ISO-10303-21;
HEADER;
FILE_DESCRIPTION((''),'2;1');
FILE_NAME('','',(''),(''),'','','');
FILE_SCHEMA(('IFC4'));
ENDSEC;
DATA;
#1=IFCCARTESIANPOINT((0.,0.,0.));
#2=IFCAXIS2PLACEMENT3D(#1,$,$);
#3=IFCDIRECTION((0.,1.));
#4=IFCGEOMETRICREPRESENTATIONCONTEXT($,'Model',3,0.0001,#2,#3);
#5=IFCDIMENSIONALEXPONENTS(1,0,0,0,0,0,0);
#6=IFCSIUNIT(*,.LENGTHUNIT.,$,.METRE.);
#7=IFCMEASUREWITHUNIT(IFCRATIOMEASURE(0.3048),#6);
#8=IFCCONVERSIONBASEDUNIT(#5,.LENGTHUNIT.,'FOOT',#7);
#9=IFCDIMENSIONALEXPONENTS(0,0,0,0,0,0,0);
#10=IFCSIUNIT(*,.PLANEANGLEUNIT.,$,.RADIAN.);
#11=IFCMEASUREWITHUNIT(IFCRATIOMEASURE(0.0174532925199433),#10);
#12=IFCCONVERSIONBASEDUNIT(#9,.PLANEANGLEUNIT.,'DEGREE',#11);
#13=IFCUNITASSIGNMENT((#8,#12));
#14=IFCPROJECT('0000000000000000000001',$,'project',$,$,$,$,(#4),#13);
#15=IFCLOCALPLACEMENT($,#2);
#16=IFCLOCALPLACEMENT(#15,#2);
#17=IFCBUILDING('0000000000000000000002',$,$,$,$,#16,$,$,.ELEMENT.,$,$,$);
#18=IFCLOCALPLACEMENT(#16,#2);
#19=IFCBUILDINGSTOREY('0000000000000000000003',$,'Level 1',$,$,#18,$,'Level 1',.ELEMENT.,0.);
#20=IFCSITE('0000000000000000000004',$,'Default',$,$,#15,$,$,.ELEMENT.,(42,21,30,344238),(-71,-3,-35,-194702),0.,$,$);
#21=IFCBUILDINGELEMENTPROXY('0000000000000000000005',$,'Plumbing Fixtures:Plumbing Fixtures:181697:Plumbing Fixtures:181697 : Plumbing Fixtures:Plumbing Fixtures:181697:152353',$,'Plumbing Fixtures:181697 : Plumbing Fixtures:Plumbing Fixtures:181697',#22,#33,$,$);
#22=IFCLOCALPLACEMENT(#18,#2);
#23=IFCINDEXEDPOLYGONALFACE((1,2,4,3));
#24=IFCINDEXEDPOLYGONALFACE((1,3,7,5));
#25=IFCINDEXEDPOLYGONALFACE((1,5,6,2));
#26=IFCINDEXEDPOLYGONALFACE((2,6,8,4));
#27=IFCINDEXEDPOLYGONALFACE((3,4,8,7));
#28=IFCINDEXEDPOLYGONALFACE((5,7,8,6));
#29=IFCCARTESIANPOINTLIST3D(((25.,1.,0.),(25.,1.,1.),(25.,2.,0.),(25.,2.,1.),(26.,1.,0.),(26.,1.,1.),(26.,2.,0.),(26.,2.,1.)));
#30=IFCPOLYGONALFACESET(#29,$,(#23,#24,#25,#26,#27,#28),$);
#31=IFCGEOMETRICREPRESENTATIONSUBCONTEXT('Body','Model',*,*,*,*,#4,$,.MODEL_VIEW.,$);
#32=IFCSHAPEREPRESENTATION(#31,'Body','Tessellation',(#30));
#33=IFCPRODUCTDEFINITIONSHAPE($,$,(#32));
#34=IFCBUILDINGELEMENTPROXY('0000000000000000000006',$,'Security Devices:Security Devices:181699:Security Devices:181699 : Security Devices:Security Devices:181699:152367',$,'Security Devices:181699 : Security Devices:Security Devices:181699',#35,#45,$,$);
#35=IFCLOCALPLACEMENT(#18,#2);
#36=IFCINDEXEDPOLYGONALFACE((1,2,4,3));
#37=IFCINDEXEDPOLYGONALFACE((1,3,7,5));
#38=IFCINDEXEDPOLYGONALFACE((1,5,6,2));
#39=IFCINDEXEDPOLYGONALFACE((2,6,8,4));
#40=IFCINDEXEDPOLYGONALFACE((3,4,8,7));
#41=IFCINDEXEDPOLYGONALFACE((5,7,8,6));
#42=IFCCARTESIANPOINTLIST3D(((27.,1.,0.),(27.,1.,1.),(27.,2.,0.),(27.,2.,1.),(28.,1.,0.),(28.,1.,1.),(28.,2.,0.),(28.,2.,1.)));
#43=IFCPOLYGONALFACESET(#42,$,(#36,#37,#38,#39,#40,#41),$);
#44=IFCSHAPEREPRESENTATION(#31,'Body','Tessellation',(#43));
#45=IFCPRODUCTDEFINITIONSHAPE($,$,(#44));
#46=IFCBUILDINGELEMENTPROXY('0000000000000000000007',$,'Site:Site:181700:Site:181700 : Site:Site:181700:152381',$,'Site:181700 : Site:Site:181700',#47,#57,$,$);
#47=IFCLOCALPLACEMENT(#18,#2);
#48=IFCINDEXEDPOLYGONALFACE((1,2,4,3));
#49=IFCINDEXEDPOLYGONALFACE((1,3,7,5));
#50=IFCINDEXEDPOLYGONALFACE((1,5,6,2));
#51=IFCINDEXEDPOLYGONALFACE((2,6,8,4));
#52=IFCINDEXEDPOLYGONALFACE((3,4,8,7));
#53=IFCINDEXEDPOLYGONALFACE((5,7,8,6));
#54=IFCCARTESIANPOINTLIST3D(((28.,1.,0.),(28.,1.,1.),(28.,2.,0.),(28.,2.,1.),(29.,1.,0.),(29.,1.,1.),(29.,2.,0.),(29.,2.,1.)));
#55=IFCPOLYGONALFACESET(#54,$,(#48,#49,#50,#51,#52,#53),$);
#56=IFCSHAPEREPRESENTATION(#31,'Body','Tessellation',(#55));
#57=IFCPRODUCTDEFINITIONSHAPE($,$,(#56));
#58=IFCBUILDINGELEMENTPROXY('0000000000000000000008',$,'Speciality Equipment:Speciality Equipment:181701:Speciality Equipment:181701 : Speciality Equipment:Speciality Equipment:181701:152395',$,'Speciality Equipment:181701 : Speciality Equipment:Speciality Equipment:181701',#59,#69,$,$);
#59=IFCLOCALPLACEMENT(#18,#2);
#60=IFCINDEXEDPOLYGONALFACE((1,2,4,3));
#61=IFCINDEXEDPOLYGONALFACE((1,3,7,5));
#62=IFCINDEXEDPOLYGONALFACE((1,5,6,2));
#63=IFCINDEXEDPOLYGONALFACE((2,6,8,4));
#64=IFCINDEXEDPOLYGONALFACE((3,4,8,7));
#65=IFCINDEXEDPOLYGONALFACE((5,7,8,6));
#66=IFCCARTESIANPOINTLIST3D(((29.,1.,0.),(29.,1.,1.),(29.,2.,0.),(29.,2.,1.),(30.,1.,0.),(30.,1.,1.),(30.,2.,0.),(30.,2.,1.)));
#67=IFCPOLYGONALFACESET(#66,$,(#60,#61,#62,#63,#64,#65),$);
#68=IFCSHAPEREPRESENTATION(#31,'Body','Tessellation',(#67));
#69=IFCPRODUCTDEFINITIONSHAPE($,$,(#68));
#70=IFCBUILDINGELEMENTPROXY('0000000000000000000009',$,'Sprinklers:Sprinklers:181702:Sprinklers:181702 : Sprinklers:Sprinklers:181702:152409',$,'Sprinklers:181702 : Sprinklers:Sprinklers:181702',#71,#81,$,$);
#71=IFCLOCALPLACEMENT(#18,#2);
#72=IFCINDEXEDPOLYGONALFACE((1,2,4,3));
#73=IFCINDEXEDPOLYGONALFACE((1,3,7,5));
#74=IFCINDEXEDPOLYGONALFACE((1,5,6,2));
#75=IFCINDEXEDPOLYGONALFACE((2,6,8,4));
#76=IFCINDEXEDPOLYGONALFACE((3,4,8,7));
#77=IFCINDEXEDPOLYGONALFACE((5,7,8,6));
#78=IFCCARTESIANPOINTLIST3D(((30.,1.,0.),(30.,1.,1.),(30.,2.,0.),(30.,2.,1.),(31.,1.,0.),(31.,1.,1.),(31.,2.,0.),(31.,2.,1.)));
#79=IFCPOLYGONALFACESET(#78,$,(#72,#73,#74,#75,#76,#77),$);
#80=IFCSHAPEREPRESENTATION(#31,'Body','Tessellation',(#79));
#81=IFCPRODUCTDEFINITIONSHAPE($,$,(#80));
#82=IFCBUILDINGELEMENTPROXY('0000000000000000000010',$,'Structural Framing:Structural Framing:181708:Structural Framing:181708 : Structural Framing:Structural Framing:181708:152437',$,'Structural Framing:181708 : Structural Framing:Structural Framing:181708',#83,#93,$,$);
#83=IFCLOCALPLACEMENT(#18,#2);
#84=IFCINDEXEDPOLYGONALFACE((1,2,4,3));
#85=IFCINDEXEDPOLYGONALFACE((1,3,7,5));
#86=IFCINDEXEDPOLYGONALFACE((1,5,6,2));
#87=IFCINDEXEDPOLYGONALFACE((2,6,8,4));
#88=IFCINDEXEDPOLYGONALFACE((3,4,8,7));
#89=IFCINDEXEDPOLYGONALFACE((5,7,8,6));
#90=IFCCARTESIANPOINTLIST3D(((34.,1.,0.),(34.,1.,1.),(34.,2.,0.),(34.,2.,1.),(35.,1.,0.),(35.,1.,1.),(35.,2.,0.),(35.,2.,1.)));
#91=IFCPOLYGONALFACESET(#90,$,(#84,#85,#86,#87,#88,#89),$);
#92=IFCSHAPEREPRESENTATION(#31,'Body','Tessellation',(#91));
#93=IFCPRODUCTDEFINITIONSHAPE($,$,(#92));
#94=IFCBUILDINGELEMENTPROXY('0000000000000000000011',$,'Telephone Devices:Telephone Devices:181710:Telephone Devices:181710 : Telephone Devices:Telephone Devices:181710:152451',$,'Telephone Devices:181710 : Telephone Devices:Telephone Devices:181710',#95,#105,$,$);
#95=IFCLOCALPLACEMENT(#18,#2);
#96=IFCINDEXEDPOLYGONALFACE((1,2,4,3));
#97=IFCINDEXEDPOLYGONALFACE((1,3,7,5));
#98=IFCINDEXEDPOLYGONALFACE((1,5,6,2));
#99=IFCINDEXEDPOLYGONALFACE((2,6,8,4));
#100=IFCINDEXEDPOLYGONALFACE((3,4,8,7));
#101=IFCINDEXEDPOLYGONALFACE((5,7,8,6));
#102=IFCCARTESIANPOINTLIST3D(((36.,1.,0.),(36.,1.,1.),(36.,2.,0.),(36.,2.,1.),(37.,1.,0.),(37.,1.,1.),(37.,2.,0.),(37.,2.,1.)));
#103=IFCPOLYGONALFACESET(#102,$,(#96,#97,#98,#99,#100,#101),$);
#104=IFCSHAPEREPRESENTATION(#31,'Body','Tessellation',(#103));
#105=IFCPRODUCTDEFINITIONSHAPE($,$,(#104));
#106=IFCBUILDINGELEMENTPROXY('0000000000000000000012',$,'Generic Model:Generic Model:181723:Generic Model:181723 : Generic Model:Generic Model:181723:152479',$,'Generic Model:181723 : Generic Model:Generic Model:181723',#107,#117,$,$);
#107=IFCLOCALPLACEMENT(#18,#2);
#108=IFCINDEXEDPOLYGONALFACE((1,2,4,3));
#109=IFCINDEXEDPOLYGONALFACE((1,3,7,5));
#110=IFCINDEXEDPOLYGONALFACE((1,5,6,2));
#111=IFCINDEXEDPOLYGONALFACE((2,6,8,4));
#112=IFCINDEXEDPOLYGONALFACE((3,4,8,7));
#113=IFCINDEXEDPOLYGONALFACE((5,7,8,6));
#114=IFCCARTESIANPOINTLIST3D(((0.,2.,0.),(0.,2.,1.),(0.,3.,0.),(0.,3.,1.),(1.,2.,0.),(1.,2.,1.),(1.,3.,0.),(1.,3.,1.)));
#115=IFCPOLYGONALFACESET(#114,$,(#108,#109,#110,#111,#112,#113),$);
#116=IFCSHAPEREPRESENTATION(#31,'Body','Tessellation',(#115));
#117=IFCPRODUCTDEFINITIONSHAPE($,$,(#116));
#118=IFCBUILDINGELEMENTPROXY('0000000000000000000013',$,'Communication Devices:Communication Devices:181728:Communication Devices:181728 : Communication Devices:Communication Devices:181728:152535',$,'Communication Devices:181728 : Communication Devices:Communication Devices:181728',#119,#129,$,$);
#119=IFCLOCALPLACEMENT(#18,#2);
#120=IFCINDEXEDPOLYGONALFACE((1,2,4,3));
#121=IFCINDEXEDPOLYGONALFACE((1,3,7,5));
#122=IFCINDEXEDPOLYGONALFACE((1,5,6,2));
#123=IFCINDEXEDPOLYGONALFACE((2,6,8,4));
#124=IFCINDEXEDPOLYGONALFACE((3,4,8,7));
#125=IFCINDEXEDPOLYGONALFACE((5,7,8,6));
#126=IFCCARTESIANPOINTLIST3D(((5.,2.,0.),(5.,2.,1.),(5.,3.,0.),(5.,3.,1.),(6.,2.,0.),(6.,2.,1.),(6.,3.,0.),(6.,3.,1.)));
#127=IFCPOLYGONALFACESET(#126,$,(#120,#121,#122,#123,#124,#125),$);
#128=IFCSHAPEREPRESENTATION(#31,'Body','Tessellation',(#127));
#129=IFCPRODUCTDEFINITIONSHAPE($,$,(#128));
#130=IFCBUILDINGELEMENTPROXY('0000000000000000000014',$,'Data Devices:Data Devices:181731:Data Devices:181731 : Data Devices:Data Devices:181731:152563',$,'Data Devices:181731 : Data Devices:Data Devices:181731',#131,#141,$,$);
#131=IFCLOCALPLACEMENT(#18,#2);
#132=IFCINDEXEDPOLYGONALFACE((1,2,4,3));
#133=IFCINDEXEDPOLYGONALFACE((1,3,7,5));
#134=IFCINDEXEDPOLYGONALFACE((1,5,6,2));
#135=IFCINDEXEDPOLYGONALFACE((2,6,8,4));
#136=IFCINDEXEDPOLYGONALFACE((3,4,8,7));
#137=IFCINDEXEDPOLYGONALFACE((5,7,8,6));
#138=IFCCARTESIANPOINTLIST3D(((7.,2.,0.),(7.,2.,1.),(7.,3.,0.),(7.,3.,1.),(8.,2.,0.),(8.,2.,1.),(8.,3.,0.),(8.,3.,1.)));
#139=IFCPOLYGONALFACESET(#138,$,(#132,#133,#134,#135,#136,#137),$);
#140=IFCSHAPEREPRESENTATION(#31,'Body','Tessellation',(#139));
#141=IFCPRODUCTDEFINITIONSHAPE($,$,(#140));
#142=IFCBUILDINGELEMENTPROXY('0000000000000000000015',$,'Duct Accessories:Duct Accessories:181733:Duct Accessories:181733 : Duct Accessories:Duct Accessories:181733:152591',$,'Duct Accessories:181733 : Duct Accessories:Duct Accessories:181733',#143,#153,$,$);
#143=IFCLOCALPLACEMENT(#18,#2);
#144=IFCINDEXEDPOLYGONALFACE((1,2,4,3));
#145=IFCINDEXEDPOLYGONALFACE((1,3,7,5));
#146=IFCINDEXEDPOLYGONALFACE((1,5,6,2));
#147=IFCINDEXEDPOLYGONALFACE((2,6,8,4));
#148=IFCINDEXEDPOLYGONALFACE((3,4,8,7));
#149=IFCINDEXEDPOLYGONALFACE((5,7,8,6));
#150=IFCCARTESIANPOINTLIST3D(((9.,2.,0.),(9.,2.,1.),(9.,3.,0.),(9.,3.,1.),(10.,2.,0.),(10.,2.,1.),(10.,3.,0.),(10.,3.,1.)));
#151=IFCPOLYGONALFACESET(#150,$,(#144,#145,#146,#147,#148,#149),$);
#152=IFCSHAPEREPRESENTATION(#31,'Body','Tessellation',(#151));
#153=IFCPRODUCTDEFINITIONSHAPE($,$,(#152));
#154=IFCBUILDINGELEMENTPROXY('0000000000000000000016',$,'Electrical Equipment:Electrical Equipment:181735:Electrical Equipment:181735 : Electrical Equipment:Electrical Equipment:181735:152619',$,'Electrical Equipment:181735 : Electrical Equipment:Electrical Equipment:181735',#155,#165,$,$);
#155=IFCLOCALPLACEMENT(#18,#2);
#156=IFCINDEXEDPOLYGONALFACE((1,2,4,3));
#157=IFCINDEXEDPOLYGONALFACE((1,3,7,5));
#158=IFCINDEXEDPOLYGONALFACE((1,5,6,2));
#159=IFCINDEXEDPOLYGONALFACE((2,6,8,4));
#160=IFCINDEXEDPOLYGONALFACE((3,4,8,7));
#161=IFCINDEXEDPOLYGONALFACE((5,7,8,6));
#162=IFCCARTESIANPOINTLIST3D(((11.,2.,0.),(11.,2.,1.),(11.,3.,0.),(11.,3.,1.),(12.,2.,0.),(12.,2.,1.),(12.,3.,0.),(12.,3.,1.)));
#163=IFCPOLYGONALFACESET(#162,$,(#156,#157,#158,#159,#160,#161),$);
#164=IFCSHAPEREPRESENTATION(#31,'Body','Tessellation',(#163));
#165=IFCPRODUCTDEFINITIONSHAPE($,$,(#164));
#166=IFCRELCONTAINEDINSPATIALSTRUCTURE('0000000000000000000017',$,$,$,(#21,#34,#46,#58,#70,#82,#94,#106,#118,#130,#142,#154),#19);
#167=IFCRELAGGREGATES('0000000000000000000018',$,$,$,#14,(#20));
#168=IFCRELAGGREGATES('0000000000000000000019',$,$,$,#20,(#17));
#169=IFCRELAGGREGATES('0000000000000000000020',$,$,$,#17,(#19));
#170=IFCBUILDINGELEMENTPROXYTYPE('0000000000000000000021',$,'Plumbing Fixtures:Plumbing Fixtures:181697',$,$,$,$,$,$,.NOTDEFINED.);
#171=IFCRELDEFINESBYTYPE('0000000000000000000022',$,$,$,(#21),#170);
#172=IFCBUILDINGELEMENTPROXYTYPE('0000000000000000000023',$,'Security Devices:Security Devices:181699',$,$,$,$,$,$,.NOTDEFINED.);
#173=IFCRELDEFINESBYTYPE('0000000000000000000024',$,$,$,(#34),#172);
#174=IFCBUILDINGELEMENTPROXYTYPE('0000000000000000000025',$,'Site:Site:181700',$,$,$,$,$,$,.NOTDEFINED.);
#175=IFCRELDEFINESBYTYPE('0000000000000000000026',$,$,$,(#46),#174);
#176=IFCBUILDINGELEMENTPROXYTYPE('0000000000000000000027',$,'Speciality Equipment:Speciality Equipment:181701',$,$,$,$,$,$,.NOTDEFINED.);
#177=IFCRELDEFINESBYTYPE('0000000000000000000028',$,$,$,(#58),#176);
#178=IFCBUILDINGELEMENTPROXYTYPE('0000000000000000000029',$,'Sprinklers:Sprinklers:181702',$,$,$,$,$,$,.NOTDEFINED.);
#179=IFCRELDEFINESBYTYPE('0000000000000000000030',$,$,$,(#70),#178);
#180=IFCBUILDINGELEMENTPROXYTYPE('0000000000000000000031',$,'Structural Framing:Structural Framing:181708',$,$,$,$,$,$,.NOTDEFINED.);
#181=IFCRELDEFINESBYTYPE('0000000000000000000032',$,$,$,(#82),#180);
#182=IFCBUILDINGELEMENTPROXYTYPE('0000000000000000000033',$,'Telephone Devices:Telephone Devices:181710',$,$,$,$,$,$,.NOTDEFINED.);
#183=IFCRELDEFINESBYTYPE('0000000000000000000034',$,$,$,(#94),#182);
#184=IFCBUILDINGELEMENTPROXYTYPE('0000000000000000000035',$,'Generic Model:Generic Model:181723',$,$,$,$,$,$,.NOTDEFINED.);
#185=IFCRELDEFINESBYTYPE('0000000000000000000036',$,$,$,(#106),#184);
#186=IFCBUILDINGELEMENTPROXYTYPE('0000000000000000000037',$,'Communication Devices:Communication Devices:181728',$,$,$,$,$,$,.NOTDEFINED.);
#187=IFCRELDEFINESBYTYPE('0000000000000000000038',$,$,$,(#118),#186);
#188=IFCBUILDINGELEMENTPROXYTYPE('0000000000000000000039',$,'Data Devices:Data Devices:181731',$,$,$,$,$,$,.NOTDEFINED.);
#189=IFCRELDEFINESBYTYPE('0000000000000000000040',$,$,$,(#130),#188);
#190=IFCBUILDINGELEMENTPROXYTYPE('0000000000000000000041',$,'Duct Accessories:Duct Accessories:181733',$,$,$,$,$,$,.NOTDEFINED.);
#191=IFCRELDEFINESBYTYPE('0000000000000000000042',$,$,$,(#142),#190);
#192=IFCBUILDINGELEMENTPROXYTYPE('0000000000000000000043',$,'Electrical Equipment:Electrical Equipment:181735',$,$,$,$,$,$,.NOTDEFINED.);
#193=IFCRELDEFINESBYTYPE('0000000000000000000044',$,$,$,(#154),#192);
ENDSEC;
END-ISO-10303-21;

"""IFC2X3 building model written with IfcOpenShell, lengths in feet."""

from ifc_helpers import new_model, entity, si_unit, converted_unit, direction, frame, frame_2d, origin, place, context, subcontext, project, spatial, rectangle, extrude, source, transform, mapped, type_object, type_shapes, element, save


model = new_model("IFC2X3")

# Units and contexts
model_context = context("Model", 3, precision=0.0001, world=origin(), true_north=direction((0.0, 1.0)))
body_context = subcontext(model_context, "Body", "Model", "MODEL_VIEW")
ifc_project = project(units=[converted_unit("LENGTHUNIT", "FOOT", entity("IfcRatioMeasure", 0.3048), si_unit("LENGTHUNIT", "METRE"), dimensions=[1, 0, 0, 0, 0, 0, 0]), converted_unit("PLANEANGLEUNIT", "DEGREE", entity("IfcRatioMeasure", 0.0174532925199433), si_unit("PLANEANGLEUNIT", "RADIAN"), dimensions=[0, 0, 0, 0, 0, 0, 0])], contexts=[model_context])

# Site, building, storey
site_placement = place(None, origin())
site = spatial("IfcSite", under=ifc_project, at=site_placement, Name="Default", CompositionType="ELEMENT", RefLatitude=(42, 21, 30, 344238), RefLongitude=(-71, -3, -35, -194702), RefElevation=0.0)
building_placement = place(site_placement, origin())
building = spatial("IfcBuilding", under=site, at=building_placement, CompositionType="ELEMENT")
storey_placement = place(building_placement, origin())
storey = spatial("IfcBuildingStorey", under=building, at=storey_placement, Name="Level 1", LongName="Level 1", CompositionType="ELEMENT", Elevation=0.0)

# Building element proxies
building_element_proxy_type_1 = type_object("IfcBuildingElementProxyType", Name="Plumbing Fixtures:Plumbing Fixtures:181697", PredefinedType="NOTDEFINED")
shared_shape_1 = source(origin(), body_context, "Body", "SweptSolid", [
    extrude(rectangle(XDim=1.0, YDim=1.0, at=frame_2d((0.0, 0.0), x_axis=(1.0, 0.0))), frame((25.5, 1.5, 0.0), z_axis=(0.0, 0.0, 1.0), x_axis=(-1.0, 0.0, 0.0)), (0.0, 0.0, 1.0), 1.0),
])
type_shapes(building_element_proxy_type_1, [shared_shape_1])
proxy_1_placement = place(storey_placement, origin())
element("IfcBuildingElementProxy", 1, at=proxy_1_placement, inside=storey, type_object=building_element_proxy_type_1, Name="Plumbing Fixtures:Plumbing Fixtures:181697:Plumbing Fixtures:181697 : Plumbing Fixtures:Plumbing Fixtures:181697:152353", ObjectType="Plumbing Fixtures:181697 : Plumbing Fixtures:Plumbing Fixtures:181697", context=body_context, shape_type="MappedRepresentation", body=[
    mapped(shared_shape_1, transform((0.0, 0.0, 0.0), scale=1.0)),
])
building_element_proxy_type_2 = type_object("IfcBuildingElementProxyType", Name="Security Devices:Security Devices:181699", PredefinedType="NOTDEFINED")
shared_shape_2 = source(origin(), body_context, "Body", "SweptSolid", [
    extrude(rectangle(XDim=1.0, YDim=1.0, at=frame_2d((0.0, 0.0), x_axis=(1.0, 0.0))), frame((27.5, 1.5, 0.0), z_axis=(0.0, 0.0, 1.0), x_axis=(-1.0, 0.0, 0.0)), (0.0, 0.0, 1.0), 1.0),
])
type_shapes(building_element_proxy_type_2, [shared_shape_2])
proxy_2_placement = place(storey_placement, origin())
element("IfcBuildingElementProxy", 2, at=proxy_2_placement, inside=storey, type_object=building_element_proxy_type_2, Name="Security Devices:Security Devices:181699:Security Devices:181699 : Security Devices:Security Devices:181699:152367", ObjectType="Security Devices:181699 : Security Devices:Security Devices:181699", context=body_context, shape_type="MappedRepresentation", body=[
    mapped(shared_shape_2, transform((0.0, 0.0, 0.0), scale=1.0)),
])
building_element_proxy_type_3 = type_object("IfcBuildingElementProxyType", Name="Site:Site:181700", PredefinedType="NOTDEFINED")
shared_shape_3 = source(origin(), body_context, "Body", "SweptSolid", [
    extrude(rectangle(XDim=1.0, YDim=1.0, at=frame_2d((0.0, 0.0), x_axis=(1.0, 0.0))), frame((28.5, 1.5, 0.0), z_axis=(0.0, 0.0, 1.0), x_axis=(-1.0, 0.0, 0.0)), (0.0, 0.0, 1.0), 1.0),
])
type_shapes(building_element_proxy_type_3, [shared_shape_3])
proxy_3_placement = place(storey_placement, origin())
element("IfcBuildingElementProxy", 3, at=proxy_3_placement, inside=storey, type_object=building_element_proxy_type_3, Name="Site:Site:181700:Site:181700 : Site:Site:181700:152381", ObjectType="Site:181700 : Site:Site:181700", context=body_context, shape_type="MappedRepresentation", body=[
    mapped(shared_shape_3, transform((0.0, 0.0, 0.0), scale=1.0)),
])
building_element_proxy_type_4 = type_object("IfcBuildingElementProxyType", Name="Speciality Equipment:Speciality Equipment:181701", PredefinedType="NOTDEFINED")
shared_shape_4 = source(origin(), body_context, "Body", "SweptSolid", [
    extrude(rectangle(XDim=1.0, YDim=1.0, at=frame_2d((0.0, 0.0), x_axis=(1.0, 0.0))), frame((29.5, 1.5, 0.0), z_axis=(0.0, 0.0, 1.0), x_axis=(-1.0, 0.0, 0.0)), (0.0, 0.0, 1.0), 1.0),
])
type_shapes(building_element_proxy_type_4, [shared_shape_4])
proxy_4_placement = place(storey_placement, origin())
element("IfcBuildingElementProxy", 4, at=proxy_4_placement, inside=storey, type_object=building_element_proxy_type_4, Name="Speciality Equipment:Speciality Equipment:181701:Speciality Equipment:181701 : Speciality Equipment:Speciality Equipment:181701:152395", ObjectType="Speciality Equipment:181701 : Speciality Equipment:Speciality Equipment:181701", context=body_context, shape_type="MappedRepresentation", body=[
    mapped(shared_shape_4, transform((0.0, 0.0, 0.0), scale=1.0)),
])
building_element_proxy_type_5 = type_object("IfcBuildingElementProxyType", Name="Sprinklers:Sprinklers:181702", PredefinedType="NOTDEFINED")
shared_shape_5 = source(origin(), body_context, "Body", "SweptSolid", [
    extrude(rectangle(XDim=1.0, YDim=1.0, at=frame_2d((0.0, 0.0), x_axis=(1.0, 0.0))), frame((30.5, 1.5, 0.0), z_axis=(0.0, 0.0, 1.0), x_axis=(-1.0, 0.0, 0.0)), (0.0, 0.0, 1.0), 1.0),
])
type_shapes(building_element_proxy_type_5, [shared_shape_5])
proxy_5_placement = place(storey_placement, origin())
element("IfcBuildingElementProxy", 5, at=proxy_5_placement, inside=storey, type_object=building_element_proxy_type_5, Name="Sprinklers:Sprinklers:181702:Sprinklers:181702 : Sprinklers:Sprinklers:181702:152409", ObjectType="Sprinklers:181702 : Sprinklers:Sprinklers:181702", context=body_context, shape_type="MappedRepresentation", body=[
    mapped(shared_shape_5, transform((0.0, 0.0, 0.0), scale=1.0)),
])
building_element_proxy_type_6 = type_object("IfcBuildingElementProxyType", Name="Structural Framing:Structural Framing:181708", PredefinedType="NOTDEFINED")
shared_shape_6 = source(origin(), body_context, "Body", "SweptSolid", [
    extrude(rectangle(XDim=1.0, YDim=1.0, at=frame_2d((0.0, 0.0), x_axis=(1.0, 0.0))), frame((34.5, 1.5, 0.0), z_axis=(0.0, 0.0, 1.0), x_axis=(-1.0, 0.0, 0.0)), (0.0, 0.0, 1.0), 1.0),
])
type_shapes(building_element_proxy_type_6, [shared_shape_6])
proxy_6_placement = place(storey_placement, origin())
element("IfcBuildingElementProxy", 6, at=proxy_6_placement, inside=storey, type_object=building_element_proxy_type_6, Name="Structural Framing:Structural Framing:181708:Structural Framing:181708 : Structural Framing:Structural Framing:181708:152437", ObjectType="Structural Framing:181708 : Structural Framing:Structural Framing:181708", context=body_context, shape_type="MappedRepresentation", body=[
    mapped(shared_shape_6, transform((0.0, 0.0, 0.0), scale=1.0)),
])
building_element_proxy_type_7 = type_object("IfcBuildingElementProxyType", Name="Telephone Devices:Telephone Devices:181710", PredefinedType="NOTDEFINED")
shared_shape_7 = source(origin(), body_context, "Body", "SweptSolid", [
    extrude(rectangle(XDim=1.0, YDim=1.0, at=frame_2d((0.0, 0.0), x_axis=(1.0, 0.0))), frame((36.5, 1.5, 0.0), z_axis=(0.0, 0.0, 1.0), x_axis=(-1.0, 0.0, 0.0)), (0.0, 0.0, 1.0), 1.0),
])
type_shapes(building_element_proxy_type_7, [shared_shape_7])
proxy_7_placement = place(storey_placement, origin())
element("IfcBuildingElementProxy", 7, at=proxy_7_placement, inside=storey, type_object=building_element_proxy_type_7, Name="Telephone Devices:Telephone Devices:181710:Telephone Devices:181710 : Telephone Devices:Telephone Devices:181710:152451", ObjectType="Telephone Devices:181710 : Telephone Devices:Telephone Devices:181710", context=body_context, shape_type="MappedRepresentation", body=[
    mapped(shared_shape_7, transform((0.0, 0.0, 0.0), scale=1.0)),
])
building_element_proxy_type_8 = type_object("IfcBuildingElementProxyType", Name="Generic Model:Generic Model:181723", PredefinedType="NOTDEFINED")
shared_shape_8 = source(origin(), body_context, "Body", "SweptSolid", [
    extrude(rectangle(XDim=1.0, YDim=1.0, at=frame_2d((0.0, 0.0), x_axis=(1.0, 0.0))), frame((0.5, 2.5, 0.0), z_axis=(0.0, 0.0, 1.0), x_axis=(-1.0, 0.0, 0.0)), (0.0, 0.0, 1.0), 1.0),
])
type_shapes(building_element_proxy_type_8, [shared_shape_8])
proxy_8_placement = place(storey_placement, origin())
element("IfcBuildingElementProxy", 8, at=proxy_8_placement, inside=storey, type_object=building_element_proxy_type_8, Name="Generic Model:Generic Model:181723:Generic Model:181723 : Generic Model:Generic Model:181723:152479", ObjectType="Generic Model:181723 : Generic Model:Generic Model:181723", context=body_context, shape_type="MappedRepresentation", body=[
    mapped(shared_shape_8, transform((0.0, 0.0, 0.0), scale=1.0)),
])
building_element_proxy_type_9 = type_object("IfcBuildingElementProxyType", Name="Communication Devices:Communication Devices:181728", PredefinedType="NOTDEFINED")
shared_shape_9 = source(origin(), body_context, "Body", "SweptSolid", [
    extrude(rectangle(XDim=1.0, YDim=1.0, at=frame_2d((0.0, 0.0), x_axis=(1.0, 0.0))), frame((5.5, 2.5, 0.0), z_axis=(0.0, 0.0, 1.0), x_axis=(-1.0, 0.0, 0.0)), (0.0, 0.0, 1.0), 1.0),
])
type_shapes(building_element_proxy_type_9, [shared_shape_9])
proxy_9_placement = place(storey_placement, origin())
element("IfcBuildingElementProxy", 9, at=proxy_9_placement, inside=storey, type_object=building_element_proxy_type_9, Name="Communication Devices:Communication Devices:181728:Communication Devices:181728 : Communication Devices:Communication Devices:181728:152535", ObjectType="Communication Devices:181728 : Communication Devices:Communication Devices:181728", context=body_context, shape_type="MappedRepresentation", body=[
    mapped(shared_shape_9, transform((0.0, 0.0, 0.0), scale=1.0)),
])
building_element_proxy_type_10 = type_object("IfcBuildingElementProxyType", Name="Data Devices:Data Devices:181731", PredefinedType="NOTDEFINED")
shared_shape_10 = source(origin(), body_context, "Body", "SweptSolid", [
    extrude(rectangle(XDim=1.0, YDim=1.0, at=frame_2d((0.0, 0.0), x_axis=(1.0, 0.0))), frame((7.5, 2.5, 0.0), z_axis=(0.0, 0.0, 1.0), x_axis=(-1.0, 0.0, 0.0)), (0.0, 0.0, 1.0), 1.0),
])
type_shapes(building_element_proxy_type_10, [shared_shape_10])
proxy_10_placement = place(storey_placement, origin())
element("IfcBuildingElementProxy", 10, at=proxy_10_placement, inside=storey, type_object=building_element_proxy_type_10, Name="Data Devices:Data Devices:181731:Data Devices:181731 : Data Devices:Data Devices:181731:152563", ObjectType="Data Devices:181731 : Data Devices:Data Devices:181731", context=body_context, shape_type="MappedRepresentation", body=[
    mapped(shared_shape_10, transform((0.0, 0.0, 0.0), scale=1.0)),
])
building_element_proxy_type_11 = type_object("IfcBuildingElementProxyType", Name="Duct Accessories:Duct Accessories:181733", PredefinedType="NOTDEFINED")
shared_shape_11 = source(origin(), body_context, "Body", "SweptSolid", [
    extrude(rectangle(XDim=1.0, YDim=1.0, at=frame_2d((0.0, 0.0), x_axis=(1.0, 0.0))), frame((9.5, 2.5, 0.0), z_axis=(0.0, 0.0, 1.0), x_axis=(-1.0, 0.0, 0.0)), (0.0, 0.0, 1.0), 1.0),
])
type_shapes(building_element_proxy_type_11, [shared_shape_11])
proxy_11_placement = place(storey_placement, origin())
element("IfcBuildingElementProxy", 11, at=proxy_11_placement, inside=storey, type_object=building_element_proxy_type_11, Name="Duct Accessories:Duct Accessories:181733:Duct Accessories:181733 : Duct Accessories:Duct Accessories:181733:152591", ObjectType="Duct Accessories:181733 : Duct Accessories:Duct Accessories:181733", context=body_context, shape_type="MappedRepresentation", body=[
    mapped(shared_shape_11, transform((0.0, 0.0, 0.0), scale=1.0)),
])
building_element_proxy_type_12 = type_object("IfcBuildingElementProxyType", Name="Electrical Equipment:Electrical Equipment:181735", PredefinedType="NOTDEFINED")
shared_shape_12 = source(origin(), body_context, "Body", "SweptSolid", [
    extrude(rectangle(XDim=1.0, YDim=1.0, at=frame_2d((0.0, 0.0), x_axis=(1.0, 0.0))), frame((11.5, 2.5, 0.0), z_axis=(0.0, 0.0, 1.0), x_axis=(-1.0, 0.0, 0.0)), (0.0, 0.0, 1.0), 1.0),
])
type_shapes(building_element_proxy_type_12, [shared_shape_12])
proxy_12_placement = place(storey_placement, origin())
element("IfcBuildingElementProxy", 12, at=proxy_12_placement, inside=storey, type_object=building_element_proxy_type_12, Name="Electrical Equipment:Electrical Equipment:181735:Electrical Equipment:181735 : Electrical Equipment:Electrical Equipment:181735:152619", ObjectType="Electrical Equipment:181735 : Electrical Equipment:Electrical Equipment:181735", context=body_context, shape_type="MappedRepresentation", body=[
    mapped(shared_shape_12, transform((0.0, 0.0, 0.0), scale=1.0)),
])

save(model, "model.ifc")
